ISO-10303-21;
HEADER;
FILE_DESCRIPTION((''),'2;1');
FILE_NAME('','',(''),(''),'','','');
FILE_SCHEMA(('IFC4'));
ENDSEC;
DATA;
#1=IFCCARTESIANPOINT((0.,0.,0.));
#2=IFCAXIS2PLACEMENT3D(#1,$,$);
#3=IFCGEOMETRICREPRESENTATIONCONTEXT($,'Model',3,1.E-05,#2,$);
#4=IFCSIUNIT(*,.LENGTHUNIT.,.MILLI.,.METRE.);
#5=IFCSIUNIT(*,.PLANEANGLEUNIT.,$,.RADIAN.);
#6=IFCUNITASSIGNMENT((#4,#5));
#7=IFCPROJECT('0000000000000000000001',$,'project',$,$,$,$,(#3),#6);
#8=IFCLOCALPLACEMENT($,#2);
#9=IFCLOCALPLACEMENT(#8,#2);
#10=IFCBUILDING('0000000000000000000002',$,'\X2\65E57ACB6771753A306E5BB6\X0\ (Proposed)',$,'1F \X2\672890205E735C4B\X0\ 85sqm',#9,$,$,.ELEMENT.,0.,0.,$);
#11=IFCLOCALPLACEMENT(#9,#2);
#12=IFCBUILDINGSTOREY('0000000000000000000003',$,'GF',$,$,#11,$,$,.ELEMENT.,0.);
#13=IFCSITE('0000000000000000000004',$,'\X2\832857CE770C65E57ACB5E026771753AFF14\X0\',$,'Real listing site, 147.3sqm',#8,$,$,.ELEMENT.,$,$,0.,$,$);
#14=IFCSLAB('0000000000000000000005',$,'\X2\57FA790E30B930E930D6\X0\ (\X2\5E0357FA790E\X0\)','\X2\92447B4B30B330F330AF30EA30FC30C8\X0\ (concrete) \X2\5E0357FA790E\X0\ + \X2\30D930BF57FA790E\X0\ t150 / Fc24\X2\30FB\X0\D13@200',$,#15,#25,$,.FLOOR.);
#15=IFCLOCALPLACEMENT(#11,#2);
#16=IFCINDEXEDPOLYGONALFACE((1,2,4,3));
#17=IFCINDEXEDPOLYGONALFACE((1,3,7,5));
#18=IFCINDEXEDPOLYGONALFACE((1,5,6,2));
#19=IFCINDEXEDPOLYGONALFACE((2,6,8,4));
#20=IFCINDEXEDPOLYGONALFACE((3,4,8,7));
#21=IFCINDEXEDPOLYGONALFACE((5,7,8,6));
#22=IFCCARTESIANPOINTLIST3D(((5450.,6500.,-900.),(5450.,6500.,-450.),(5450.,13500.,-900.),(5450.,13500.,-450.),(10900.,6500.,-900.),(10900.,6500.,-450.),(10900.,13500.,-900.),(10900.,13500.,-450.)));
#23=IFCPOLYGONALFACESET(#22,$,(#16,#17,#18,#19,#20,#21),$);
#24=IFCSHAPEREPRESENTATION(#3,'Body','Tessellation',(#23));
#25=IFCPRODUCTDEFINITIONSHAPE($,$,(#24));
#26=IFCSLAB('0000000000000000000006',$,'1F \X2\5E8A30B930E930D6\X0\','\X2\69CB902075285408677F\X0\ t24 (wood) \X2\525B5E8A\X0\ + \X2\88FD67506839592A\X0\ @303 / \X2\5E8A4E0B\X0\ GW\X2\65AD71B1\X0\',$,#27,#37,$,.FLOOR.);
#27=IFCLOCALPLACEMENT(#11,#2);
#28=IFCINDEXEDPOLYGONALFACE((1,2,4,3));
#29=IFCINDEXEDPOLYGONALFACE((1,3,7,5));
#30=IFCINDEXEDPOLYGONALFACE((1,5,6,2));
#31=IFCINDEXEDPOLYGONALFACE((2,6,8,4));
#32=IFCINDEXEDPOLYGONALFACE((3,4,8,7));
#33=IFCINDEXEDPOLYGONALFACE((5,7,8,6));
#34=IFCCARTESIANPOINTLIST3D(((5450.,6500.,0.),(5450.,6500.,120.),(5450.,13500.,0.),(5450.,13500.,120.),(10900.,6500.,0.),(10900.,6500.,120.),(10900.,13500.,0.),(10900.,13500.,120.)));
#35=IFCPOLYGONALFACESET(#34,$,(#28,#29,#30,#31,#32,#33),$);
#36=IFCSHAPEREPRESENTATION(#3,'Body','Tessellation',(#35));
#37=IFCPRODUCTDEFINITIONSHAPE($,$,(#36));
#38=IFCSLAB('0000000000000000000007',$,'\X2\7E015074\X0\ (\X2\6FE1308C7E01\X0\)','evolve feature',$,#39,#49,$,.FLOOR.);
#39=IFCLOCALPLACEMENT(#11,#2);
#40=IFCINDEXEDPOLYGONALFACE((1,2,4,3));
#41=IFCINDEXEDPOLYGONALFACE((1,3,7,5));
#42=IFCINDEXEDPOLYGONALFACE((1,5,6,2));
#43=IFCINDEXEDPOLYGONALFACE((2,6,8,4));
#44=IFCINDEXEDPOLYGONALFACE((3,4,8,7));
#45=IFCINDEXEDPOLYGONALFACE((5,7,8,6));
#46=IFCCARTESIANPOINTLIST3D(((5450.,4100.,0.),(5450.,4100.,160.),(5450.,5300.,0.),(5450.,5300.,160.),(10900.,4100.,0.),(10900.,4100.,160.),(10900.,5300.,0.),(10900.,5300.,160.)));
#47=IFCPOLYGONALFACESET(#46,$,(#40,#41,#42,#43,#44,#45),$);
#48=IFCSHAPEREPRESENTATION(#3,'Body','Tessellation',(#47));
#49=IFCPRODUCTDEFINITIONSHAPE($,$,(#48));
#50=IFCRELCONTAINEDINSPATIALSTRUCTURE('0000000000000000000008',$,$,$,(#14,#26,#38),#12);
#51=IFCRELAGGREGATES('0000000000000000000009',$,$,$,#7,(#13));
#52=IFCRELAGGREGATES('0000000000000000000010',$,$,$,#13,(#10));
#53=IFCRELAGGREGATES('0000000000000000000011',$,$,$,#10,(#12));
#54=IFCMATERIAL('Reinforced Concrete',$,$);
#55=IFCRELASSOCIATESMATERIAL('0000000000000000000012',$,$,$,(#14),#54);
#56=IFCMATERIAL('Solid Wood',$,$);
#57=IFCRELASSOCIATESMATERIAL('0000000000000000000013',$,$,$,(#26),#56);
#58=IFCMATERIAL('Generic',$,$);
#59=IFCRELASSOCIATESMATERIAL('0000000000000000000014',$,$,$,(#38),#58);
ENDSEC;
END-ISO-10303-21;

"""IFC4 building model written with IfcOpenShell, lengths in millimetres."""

from ifc_helpers import new_model, si_unit, frame, frame_2d, origin, place, context, project, spatial, rectangle, extrude, material, element, save


model = new_model("IFC4")

# Units and contexts
model_context = context("Model", 3, precision=1e-05, world=origin())
ifc_project = project(units=[si_unit("LENGTHUNIT", "METRE", prefix="MILLI"), si_unit("PLANEANGLEUNIT", "RADIAN")], contexts=[model_context])

# Site, building, storey
site_placement = place(None, origin())
site = spatial("IfcSite", under=ifc_project, at=site_placement, Name="茨城県日立市東町４", ObjectType="Real listing site, 147.3sqm", CompositionType="ELEMENT", RefElevation=0.0)
building_placement = place(site_placement, origin())
building = spatial("IfcBuilding", under=site, at=building_placement, Name="日立東町の家 (Proposed)", ObjectType="1F 木造平屋 85sqm", CompositionType="ELEMENT", ElevationOfRefHeight=0.0, ElevationOfTerrain=0.0)
storey_placement = place(building_placement, origin())
storey = spatial("IfcBuildingStorey", under=building, at=storey_placement, Name="GF", CompositionType="ELEMENT", Elevation=0.0)

# Slabs
ifc_material_1 = material(Name="Reinforced Concrete")
slab_1_placement = place(storey_placement, frame((2725.0, 3250.0, -450.0)))
element("IfcSlab", 1, at=slab_1_placement, inside=storey, material=ifc_material_1, Name="基礎スラブ (布基礎)", Description="鉄筋コンクリート (concrete) 布基礎 + ベタ基礎 t150 / Fc24・D13@200", PredefinedType="FLOOR", context=model_context, shape_type="SweptSolid", body=[
    extrude(rectangle(XDim=5450.0, YDim=7000.0, at=frame_2d((2725.0, 3500.0))), frame((2725.0, 3250.0, -450.0)), (0.0, 0.0, 1.0), 450.0),
])
ifc_material_2 = material(Name="Solid Wood")
slab_2_placement = place(storey_placement, frame((2725.0, 3250.0, 0.0)))
element("IfcSlab", 2, at=slab_2_placement, inside=storey, material=ifc_material_2, Name="1F 床スラブ", Description="構造用合板 t24 (wood) 剛床 + 製材根太 @303 / 床下 GW断熱", PredefinedType="FLOOR", context=model_context, shape_type="SweptSolid", body=[
    extrude(rectangle(XDim=5450.0, YDim=7000.0, at=frame_2d((2725.0, 3500.0))), frame((2725.0, 3250.0, 0.0)), (0.0, 0.0, 1.0), 120.0),
])
ifc_material_3 = material(Name="Generic")
slab_3_placement = place(storey_placement, frame((2725.0, 2050.0, 0.0)))
element("IfcSlab", 3, at=slab_3_placement, inside=storey, material=ifc_material_3, Name="縁側 (濡れ縁)", Description="evolve feature", PredefinedType="FLOOR", context=model_context, shape_type="SweptSolid", body=[
    extrude(rectangle(XDim=5450.0, YDim=1200.0, at=frame_2d((2725.0, 600.0))), frame((2725.0, 2050.0, 0.0)), (0.0, 0.0, 1.0), 160.0),
])

save(model, "model.ifc")
